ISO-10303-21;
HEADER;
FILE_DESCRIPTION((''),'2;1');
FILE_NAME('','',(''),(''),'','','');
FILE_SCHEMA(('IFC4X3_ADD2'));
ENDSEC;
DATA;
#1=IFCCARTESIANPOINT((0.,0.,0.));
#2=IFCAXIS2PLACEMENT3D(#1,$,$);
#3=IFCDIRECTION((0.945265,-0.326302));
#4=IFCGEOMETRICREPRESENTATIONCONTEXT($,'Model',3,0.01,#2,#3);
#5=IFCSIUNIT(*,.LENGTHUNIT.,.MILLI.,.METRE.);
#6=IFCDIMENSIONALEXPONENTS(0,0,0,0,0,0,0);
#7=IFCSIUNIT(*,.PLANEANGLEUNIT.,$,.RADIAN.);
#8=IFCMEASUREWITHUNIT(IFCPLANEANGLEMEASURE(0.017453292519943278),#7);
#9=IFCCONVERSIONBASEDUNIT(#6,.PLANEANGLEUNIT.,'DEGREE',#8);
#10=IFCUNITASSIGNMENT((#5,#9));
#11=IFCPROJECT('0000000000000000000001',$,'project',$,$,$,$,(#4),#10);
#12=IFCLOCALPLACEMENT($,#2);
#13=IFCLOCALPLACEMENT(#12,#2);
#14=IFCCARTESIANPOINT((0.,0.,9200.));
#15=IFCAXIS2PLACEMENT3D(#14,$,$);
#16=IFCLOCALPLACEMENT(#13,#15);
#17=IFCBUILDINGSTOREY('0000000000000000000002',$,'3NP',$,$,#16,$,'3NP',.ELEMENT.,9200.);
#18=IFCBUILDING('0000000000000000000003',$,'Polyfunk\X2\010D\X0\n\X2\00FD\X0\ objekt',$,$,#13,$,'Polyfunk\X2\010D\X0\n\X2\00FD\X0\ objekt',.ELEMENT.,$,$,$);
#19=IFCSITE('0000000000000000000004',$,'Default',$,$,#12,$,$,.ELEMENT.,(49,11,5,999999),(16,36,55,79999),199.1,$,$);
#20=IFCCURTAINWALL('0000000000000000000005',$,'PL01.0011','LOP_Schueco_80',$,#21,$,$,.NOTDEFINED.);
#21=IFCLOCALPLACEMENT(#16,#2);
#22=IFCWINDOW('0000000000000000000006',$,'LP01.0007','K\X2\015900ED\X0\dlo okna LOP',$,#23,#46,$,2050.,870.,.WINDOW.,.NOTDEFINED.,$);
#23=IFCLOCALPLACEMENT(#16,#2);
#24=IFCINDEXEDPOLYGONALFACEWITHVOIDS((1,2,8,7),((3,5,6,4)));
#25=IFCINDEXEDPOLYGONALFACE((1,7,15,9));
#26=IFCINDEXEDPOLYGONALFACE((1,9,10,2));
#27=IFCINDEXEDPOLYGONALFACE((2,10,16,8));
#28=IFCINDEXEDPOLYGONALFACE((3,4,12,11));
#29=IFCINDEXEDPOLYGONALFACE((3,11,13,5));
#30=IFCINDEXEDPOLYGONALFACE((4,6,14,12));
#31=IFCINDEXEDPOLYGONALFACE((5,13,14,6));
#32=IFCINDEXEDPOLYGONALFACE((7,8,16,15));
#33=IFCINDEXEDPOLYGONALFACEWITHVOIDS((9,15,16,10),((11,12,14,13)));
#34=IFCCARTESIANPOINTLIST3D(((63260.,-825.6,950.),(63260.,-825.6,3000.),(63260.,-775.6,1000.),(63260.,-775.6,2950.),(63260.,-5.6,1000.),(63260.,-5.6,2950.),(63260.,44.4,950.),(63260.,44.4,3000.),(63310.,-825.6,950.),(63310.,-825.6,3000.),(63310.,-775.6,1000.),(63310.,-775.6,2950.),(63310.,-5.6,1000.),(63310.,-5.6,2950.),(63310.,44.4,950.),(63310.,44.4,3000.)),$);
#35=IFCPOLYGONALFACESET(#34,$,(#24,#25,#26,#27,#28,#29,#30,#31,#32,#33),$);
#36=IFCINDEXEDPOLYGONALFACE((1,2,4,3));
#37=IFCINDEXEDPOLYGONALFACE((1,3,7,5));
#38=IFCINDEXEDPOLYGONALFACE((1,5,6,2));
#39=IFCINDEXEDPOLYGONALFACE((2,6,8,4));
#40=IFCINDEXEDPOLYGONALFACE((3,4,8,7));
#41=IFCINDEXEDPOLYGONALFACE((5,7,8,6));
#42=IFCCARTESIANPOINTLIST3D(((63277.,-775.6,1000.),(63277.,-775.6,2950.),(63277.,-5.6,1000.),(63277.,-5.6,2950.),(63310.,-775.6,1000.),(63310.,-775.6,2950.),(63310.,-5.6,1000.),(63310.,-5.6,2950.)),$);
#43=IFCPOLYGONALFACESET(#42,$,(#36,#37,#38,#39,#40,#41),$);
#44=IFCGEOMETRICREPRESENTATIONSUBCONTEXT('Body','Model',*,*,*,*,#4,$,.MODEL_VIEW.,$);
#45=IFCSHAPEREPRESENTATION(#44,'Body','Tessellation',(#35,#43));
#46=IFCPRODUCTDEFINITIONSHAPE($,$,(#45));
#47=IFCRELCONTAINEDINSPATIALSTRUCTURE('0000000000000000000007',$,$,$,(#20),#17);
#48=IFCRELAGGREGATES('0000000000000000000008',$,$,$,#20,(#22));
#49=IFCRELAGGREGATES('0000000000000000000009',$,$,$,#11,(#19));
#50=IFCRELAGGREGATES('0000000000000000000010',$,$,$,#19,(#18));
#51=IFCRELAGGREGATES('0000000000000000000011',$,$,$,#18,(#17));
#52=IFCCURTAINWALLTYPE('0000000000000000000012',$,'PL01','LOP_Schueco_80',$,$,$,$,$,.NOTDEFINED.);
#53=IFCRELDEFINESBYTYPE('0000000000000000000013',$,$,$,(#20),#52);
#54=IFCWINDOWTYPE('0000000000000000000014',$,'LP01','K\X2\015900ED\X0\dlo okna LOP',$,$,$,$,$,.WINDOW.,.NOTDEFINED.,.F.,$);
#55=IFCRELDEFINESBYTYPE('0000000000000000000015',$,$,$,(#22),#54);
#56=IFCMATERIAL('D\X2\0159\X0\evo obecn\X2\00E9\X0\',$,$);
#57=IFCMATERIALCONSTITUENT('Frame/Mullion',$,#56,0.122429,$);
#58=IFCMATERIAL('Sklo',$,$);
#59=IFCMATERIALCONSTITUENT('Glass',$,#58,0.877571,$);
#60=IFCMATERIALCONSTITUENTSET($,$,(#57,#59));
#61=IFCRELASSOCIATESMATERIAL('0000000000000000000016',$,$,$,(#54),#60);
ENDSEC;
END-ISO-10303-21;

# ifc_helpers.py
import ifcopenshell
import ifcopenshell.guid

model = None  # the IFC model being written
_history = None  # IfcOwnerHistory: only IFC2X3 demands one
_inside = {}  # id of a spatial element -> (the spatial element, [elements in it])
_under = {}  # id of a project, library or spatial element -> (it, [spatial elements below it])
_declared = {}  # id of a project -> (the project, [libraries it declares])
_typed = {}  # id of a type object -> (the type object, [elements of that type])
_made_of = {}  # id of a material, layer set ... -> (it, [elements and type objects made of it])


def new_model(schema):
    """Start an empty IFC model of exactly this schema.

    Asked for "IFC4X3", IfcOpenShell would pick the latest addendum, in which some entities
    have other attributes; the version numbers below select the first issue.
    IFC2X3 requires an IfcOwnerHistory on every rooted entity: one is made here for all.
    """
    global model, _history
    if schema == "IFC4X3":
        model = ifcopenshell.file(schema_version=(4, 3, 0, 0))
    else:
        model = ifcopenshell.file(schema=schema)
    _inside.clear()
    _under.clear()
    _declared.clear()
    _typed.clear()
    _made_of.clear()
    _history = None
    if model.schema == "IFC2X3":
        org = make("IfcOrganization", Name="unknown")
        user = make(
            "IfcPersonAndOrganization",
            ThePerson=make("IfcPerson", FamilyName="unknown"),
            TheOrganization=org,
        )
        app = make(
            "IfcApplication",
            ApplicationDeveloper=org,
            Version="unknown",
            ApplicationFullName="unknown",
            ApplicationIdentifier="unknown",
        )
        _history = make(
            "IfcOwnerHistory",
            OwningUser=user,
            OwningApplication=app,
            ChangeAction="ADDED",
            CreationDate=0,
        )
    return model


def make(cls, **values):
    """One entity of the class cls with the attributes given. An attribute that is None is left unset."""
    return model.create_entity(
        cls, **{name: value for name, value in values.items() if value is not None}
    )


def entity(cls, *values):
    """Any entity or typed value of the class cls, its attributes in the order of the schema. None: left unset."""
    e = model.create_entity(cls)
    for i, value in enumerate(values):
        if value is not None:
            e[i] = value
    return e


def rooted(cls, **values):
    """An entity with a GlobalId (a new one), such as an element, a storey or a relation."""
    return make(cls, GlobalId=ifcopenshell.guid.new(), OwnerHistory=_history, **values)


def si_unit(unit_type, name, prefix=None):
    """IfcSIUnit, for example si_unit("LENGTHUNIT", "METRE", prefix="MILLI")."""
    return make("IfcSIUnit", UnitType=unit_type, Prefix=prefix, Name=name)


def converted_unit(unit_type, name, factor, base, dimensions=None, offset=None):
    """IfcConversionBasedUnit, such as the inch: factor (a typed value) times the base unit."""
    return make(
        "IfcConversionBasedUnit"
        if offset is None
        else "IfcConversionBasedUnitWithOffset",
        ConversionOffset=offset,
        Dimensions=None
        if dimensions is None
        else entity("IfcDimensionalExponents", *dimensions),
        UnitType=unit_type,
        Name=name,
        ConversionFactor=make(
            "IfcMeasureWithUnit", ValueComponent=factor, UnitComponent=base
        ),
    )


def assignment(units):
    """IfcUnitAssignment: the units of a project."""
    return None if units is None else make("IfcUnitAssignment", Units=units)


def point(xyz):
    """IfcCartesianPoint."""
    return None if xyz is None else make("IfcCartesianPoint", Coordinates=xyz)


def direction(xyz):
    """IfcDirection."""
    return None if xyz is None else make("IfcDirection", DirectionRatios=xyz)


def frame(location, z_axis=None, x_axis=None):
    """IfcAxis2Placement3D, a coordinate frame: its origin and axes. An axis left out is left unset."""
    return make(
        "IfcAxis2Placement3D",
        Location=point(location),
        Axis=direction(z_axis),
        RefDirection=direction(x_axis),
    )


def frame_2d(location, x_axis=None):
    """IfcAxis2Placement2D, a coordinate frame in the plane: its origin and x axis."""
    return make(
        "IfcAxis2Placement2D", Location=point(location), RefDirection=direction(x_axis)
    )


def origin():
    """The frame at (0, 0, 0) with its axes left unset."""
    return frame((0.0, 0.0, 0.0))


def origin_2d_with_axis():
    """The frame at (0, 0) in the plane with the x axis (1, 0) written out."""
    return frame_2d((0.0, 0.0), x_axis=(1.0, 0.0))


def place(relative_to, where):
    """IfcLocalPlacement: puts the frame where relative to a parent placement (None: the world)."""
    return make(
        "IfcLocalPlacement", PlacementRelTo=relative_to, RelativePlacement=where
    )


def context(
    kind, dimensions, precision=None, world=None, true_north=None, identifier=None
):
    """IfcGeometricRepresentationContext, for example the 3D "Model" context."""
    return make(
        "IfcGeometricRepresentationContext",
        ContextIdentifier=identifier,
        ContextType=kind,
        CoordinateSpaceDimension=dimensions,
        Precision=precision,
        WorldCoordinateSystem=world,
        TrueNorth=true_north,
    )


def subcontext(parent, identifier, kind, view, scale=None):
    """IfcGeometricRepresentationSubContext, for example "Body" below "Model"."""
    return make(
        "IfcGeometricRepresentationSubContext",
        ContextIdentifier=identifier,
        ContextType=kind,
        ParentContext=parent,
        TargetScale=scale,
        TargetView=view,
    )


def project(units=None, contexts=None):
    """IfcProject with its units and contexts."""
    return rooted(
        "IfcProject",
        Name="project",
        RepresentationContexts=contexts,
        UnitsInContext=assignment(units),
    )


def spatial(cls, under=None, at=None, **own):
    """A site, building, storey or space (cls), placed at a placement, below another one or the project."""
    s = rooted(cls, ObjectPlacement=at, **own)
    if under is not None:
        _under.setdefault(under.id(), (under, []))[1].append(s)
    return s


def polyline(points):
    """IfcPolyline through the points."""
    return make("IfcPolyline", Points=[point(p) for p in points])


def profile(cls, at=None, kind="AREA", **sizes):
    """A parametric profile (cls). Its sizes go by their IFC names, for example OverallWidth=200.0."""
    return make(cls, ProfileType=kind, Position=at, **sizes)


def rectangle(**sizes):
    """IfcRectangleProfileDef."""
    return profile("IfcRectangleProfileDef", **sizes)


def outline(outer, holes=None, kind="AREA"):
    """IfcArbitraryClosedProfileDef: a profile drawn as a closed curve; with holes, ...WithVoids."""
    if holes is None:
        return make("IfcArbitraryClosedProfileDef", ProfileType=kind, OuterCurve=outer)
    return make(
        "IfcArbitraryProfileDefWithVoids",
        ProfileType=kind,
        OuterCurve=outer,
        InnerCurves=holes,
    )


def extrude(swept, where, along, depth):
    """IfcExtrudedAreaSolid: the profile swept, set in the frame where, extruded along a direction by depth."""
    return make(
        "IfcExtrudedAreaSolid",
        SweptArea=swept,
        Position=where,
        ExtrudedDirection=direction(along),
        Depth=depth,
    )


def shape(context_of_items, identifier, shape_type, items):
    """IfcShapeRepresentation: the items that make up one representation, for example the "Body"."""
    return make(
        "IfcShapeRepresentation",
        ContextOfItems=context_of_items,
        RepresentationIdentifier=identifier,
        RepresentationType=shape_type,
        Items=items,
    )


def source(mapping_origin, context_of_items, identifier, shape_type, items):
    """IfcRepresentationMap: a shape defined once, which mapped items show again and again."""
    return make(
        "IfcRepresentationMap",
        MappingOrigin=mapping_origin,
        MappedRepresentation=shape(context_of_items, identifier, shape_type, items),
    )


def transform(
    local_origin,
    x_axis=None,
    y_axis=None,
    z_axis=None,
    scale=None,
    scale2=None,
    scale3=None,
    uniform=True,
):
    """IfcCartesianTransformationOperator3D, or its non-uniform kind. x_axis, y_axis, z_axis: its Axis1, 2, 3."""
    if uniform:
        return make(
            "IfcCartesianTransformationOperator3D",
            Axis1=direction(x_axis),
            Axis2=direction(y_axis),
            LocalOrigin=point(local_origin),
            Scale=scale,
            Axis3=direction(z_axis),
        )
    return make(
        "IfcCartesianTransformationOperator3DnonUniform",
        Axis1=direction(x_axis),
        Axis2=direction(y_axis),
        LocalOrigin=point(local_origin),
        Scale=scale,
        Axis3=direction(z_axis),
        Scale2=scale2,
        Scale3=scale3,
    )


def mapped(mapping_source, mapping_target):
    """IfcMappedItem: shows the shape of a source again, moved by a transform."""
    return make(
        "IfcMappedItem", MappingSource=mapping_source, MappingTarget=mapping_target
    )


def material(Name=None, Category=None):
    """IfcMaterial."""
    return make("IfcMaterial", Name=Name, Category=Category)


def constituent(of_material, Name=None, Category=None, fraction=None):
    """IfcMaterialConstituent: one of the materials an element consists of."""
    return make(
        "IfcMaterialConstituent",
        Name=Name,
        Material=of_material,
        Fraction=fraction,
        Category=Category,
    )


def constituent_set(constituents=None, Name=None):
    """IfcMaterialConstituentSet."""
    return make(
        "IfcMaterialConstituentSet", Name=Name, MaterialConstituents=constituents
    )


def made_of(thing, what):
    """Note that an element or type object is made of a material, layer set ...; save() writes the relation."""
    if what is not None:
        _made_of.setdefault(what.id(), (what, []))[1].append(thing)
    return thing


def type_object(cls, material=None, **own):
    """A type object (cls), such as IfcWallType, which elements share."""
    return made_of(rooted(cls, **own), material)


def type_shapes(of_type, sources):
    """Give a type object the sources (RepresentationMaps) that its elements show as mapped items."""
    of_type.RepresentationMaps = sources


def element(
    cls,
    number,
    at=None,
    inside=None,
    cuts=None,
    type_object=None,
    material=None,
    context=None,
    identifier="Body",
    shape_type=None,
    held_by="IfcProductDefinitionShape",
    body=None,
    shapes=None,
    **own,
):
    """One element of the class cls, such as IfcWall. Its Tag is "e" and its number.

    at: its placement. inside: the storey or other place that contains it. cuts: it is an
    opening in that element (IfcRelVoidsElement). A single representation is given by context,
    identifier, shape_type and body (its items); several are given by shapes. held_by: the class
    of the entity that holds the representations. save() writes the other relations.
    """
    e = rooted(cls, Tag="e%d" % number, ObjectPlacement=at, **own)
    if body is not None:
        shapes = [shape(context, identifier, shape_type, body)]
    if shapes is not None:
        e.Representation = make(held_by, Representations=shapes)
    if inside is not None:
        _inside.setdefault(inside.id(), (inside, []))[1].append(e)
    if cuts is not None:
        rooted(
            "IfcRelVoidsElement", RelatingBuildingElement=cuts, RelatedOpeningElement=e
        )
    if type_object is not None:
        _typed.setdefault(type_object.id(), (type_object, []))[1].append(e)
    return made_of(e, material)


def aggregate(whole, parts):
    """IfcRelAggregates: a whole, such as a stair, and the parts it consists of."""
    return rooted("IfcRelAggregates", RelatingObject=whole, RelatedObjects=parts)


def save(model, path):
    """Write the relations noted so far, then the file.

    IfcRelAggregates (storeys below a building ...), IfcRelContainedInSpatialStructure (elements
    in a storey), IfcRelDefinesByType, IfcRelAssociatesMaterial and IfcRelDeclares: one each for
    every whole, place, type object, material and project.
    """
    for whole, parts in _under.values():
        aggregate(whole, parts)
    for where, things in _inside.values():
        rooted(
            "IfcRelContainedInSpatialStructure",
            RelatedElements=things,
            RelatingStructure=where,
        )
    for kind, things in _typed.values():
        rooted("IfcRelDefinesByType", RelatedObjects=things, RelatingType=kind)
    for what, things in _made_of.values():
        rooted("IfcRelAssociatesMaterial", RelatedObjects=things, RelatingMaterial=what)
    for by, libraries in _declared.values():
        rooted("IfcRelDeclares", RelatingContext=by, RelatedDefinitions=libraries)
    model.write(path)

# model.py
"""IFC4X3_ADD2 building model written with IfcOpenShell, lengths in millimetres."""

from ifc_helpers import new_model, entity, si_unit, converted_unit, direction, frame, origin, origin_2d_with_axis, place, context, subcontext, project, spatial, polyline, rectangle, outline, extrude, source, transform, mapped, material, constituent, constituent_set, type_object, type_shapes, element, aggregate, save


model = new_model("IFC4X3_ADD2")

# Units and contexts
model_context = context("Model", 3, precision=0.01, world=origin(), true_north=direction((0.945265, -0.326302)))
body_context = subcontext(model_context, "Body", "Model", "MODEL_VIEW")
ifc_project = project(units=[si_unit("LENGTHUNIT", "METRE", prefix="MILLI"), converted_unit("PLANEANGLEUNIT", "DEGREE", entity("IfcPlaneAngleMeasure", 0.017453292519943278), si_unit("PLANEANGLEUNIT", "RADIAN"), dimensions=[0, 0, 0, 0, 0, 0, 0])], contexts=[model_context])

# Site, building, storey
site_placement = place(None, origin())
site = spatial("IfcSite", under=ifc_project, at=site_placement, Name="Default", CompositionType="ELEMENT", RefLatitude=(49, 11, 5, 999999), RefLongitude=(16, 36, 55, 79999), RefElevation=199.1)
building_placement = place(site_placement, origin())
building = spatial("IfcBuilding", under=site, at=building_placement, Name="Polyfunkčný objekt", LongName="Polyfunkčný objekt", CompositionType="ELEMENT")
storey_placement = place(building_placement, frame((0.0, 0.0, 9200.0)))
storey = spatial("IfcBuildingStorey", under=building, at=storey_placement, Name="3NP", LongName="3NP", CompositionType="ELEMENT", Elevation=9200.0)

# Curtain wall, window
curtain_wall_type = type_object("IfcCurtainWallType", Name="PL01", Description="LOP_Schueco_80", PredefinedType="NOTDEFINED")
curtain_wall_placement = place(storey_placement, frame((0.0, 0.0, -9200.0)))
curtain_wall = element("IfcCurtainWall", 1, at=curtain_wall_placement, inside=storey, type_object=curtain_wall_type, Name="PL01.0011", Description="LOP_Schueco_80", PredefinedType="NOTDEFINED")
ifc_material_1 = material(Name="Sklo")
ifc_material_2 = material(Name="Dřevo obecné")
ifc_constituent_1 = constituent(ifc_material_2, Name="Frame/Mullion", fraction=0.122429)
ifc_constituent_2 = constituent(ifc_material_1, Name="Glass", fraction=0.877571)
ifc_constituent_set = constituent_set(constituents=[ifc_constituent_1, ifc_constituent_2])
window_type = type_object("IfcWindowType", Name="LP01", Description="Křídlo okna LOP", ParameterTakesPrecedence=False, PartitioningType="NOTDEFINED", PredefinedType="WINDOW", material=ifc_constituent_set)
shared_shape_1 = source(origin(), body_context, "Body", "SweptSolid", [
    extrude(outline(polyline([(-1025.0, -435.0), (1025.0, -435.0), (1025.0, 435.0), (-1025.0, 435.0), (-1025.0, -435.0)]), holes=[polyline([(-975.0, -385.0), (-975.0, 385.0), (975.0, 385.0), (975.0, -385.0), (-975.0, -385.0)])]), frame((0.0, 0.0, 1025.0), z_axis=(0.0, 1.0, 0.0), x_axis=(0.0, 0.0, -1.0)), (0.0, 0.0, 1.0), 50.0),
    extrude(rectangle(XDim=33.0, YDim=770.0, at=origin_2d_with_axis()), frame((0.0, 33.5, 50.0), z_axis=(0.0, 0.0, 1.0), x_axis=(0.0, -1.0, 0.0)), (0.0, 0.0, 1.0), 1950.0),
])
type_shapes(window_type, [shared_shape_1])
window_placement = place(curtain_wall_placement, frame((63260.0, -390.6, 10150.0), z_axis=(0.0, 0.0, 1.0), x_axis=(0.0, -1.0, 0.0)))
window = element("IfcWindow", 2, at=window_placement, type_object=window_type, Name="LP01.0007", Description="Křídlo okna LOP", OverallHeight=2050.0, OverallWidth=870.0, PartitioningType="NOTDEFINED", PredefinedType="WINDOW", context=body_context, shape_type="MappedRepresentation", body=[
    mapped(shared_shape_1, transform((0.0, 0.0, 0.0), scale=1.0)),
])
aggregate(curtain_wall, [window])

save(model, "model.ifc")
